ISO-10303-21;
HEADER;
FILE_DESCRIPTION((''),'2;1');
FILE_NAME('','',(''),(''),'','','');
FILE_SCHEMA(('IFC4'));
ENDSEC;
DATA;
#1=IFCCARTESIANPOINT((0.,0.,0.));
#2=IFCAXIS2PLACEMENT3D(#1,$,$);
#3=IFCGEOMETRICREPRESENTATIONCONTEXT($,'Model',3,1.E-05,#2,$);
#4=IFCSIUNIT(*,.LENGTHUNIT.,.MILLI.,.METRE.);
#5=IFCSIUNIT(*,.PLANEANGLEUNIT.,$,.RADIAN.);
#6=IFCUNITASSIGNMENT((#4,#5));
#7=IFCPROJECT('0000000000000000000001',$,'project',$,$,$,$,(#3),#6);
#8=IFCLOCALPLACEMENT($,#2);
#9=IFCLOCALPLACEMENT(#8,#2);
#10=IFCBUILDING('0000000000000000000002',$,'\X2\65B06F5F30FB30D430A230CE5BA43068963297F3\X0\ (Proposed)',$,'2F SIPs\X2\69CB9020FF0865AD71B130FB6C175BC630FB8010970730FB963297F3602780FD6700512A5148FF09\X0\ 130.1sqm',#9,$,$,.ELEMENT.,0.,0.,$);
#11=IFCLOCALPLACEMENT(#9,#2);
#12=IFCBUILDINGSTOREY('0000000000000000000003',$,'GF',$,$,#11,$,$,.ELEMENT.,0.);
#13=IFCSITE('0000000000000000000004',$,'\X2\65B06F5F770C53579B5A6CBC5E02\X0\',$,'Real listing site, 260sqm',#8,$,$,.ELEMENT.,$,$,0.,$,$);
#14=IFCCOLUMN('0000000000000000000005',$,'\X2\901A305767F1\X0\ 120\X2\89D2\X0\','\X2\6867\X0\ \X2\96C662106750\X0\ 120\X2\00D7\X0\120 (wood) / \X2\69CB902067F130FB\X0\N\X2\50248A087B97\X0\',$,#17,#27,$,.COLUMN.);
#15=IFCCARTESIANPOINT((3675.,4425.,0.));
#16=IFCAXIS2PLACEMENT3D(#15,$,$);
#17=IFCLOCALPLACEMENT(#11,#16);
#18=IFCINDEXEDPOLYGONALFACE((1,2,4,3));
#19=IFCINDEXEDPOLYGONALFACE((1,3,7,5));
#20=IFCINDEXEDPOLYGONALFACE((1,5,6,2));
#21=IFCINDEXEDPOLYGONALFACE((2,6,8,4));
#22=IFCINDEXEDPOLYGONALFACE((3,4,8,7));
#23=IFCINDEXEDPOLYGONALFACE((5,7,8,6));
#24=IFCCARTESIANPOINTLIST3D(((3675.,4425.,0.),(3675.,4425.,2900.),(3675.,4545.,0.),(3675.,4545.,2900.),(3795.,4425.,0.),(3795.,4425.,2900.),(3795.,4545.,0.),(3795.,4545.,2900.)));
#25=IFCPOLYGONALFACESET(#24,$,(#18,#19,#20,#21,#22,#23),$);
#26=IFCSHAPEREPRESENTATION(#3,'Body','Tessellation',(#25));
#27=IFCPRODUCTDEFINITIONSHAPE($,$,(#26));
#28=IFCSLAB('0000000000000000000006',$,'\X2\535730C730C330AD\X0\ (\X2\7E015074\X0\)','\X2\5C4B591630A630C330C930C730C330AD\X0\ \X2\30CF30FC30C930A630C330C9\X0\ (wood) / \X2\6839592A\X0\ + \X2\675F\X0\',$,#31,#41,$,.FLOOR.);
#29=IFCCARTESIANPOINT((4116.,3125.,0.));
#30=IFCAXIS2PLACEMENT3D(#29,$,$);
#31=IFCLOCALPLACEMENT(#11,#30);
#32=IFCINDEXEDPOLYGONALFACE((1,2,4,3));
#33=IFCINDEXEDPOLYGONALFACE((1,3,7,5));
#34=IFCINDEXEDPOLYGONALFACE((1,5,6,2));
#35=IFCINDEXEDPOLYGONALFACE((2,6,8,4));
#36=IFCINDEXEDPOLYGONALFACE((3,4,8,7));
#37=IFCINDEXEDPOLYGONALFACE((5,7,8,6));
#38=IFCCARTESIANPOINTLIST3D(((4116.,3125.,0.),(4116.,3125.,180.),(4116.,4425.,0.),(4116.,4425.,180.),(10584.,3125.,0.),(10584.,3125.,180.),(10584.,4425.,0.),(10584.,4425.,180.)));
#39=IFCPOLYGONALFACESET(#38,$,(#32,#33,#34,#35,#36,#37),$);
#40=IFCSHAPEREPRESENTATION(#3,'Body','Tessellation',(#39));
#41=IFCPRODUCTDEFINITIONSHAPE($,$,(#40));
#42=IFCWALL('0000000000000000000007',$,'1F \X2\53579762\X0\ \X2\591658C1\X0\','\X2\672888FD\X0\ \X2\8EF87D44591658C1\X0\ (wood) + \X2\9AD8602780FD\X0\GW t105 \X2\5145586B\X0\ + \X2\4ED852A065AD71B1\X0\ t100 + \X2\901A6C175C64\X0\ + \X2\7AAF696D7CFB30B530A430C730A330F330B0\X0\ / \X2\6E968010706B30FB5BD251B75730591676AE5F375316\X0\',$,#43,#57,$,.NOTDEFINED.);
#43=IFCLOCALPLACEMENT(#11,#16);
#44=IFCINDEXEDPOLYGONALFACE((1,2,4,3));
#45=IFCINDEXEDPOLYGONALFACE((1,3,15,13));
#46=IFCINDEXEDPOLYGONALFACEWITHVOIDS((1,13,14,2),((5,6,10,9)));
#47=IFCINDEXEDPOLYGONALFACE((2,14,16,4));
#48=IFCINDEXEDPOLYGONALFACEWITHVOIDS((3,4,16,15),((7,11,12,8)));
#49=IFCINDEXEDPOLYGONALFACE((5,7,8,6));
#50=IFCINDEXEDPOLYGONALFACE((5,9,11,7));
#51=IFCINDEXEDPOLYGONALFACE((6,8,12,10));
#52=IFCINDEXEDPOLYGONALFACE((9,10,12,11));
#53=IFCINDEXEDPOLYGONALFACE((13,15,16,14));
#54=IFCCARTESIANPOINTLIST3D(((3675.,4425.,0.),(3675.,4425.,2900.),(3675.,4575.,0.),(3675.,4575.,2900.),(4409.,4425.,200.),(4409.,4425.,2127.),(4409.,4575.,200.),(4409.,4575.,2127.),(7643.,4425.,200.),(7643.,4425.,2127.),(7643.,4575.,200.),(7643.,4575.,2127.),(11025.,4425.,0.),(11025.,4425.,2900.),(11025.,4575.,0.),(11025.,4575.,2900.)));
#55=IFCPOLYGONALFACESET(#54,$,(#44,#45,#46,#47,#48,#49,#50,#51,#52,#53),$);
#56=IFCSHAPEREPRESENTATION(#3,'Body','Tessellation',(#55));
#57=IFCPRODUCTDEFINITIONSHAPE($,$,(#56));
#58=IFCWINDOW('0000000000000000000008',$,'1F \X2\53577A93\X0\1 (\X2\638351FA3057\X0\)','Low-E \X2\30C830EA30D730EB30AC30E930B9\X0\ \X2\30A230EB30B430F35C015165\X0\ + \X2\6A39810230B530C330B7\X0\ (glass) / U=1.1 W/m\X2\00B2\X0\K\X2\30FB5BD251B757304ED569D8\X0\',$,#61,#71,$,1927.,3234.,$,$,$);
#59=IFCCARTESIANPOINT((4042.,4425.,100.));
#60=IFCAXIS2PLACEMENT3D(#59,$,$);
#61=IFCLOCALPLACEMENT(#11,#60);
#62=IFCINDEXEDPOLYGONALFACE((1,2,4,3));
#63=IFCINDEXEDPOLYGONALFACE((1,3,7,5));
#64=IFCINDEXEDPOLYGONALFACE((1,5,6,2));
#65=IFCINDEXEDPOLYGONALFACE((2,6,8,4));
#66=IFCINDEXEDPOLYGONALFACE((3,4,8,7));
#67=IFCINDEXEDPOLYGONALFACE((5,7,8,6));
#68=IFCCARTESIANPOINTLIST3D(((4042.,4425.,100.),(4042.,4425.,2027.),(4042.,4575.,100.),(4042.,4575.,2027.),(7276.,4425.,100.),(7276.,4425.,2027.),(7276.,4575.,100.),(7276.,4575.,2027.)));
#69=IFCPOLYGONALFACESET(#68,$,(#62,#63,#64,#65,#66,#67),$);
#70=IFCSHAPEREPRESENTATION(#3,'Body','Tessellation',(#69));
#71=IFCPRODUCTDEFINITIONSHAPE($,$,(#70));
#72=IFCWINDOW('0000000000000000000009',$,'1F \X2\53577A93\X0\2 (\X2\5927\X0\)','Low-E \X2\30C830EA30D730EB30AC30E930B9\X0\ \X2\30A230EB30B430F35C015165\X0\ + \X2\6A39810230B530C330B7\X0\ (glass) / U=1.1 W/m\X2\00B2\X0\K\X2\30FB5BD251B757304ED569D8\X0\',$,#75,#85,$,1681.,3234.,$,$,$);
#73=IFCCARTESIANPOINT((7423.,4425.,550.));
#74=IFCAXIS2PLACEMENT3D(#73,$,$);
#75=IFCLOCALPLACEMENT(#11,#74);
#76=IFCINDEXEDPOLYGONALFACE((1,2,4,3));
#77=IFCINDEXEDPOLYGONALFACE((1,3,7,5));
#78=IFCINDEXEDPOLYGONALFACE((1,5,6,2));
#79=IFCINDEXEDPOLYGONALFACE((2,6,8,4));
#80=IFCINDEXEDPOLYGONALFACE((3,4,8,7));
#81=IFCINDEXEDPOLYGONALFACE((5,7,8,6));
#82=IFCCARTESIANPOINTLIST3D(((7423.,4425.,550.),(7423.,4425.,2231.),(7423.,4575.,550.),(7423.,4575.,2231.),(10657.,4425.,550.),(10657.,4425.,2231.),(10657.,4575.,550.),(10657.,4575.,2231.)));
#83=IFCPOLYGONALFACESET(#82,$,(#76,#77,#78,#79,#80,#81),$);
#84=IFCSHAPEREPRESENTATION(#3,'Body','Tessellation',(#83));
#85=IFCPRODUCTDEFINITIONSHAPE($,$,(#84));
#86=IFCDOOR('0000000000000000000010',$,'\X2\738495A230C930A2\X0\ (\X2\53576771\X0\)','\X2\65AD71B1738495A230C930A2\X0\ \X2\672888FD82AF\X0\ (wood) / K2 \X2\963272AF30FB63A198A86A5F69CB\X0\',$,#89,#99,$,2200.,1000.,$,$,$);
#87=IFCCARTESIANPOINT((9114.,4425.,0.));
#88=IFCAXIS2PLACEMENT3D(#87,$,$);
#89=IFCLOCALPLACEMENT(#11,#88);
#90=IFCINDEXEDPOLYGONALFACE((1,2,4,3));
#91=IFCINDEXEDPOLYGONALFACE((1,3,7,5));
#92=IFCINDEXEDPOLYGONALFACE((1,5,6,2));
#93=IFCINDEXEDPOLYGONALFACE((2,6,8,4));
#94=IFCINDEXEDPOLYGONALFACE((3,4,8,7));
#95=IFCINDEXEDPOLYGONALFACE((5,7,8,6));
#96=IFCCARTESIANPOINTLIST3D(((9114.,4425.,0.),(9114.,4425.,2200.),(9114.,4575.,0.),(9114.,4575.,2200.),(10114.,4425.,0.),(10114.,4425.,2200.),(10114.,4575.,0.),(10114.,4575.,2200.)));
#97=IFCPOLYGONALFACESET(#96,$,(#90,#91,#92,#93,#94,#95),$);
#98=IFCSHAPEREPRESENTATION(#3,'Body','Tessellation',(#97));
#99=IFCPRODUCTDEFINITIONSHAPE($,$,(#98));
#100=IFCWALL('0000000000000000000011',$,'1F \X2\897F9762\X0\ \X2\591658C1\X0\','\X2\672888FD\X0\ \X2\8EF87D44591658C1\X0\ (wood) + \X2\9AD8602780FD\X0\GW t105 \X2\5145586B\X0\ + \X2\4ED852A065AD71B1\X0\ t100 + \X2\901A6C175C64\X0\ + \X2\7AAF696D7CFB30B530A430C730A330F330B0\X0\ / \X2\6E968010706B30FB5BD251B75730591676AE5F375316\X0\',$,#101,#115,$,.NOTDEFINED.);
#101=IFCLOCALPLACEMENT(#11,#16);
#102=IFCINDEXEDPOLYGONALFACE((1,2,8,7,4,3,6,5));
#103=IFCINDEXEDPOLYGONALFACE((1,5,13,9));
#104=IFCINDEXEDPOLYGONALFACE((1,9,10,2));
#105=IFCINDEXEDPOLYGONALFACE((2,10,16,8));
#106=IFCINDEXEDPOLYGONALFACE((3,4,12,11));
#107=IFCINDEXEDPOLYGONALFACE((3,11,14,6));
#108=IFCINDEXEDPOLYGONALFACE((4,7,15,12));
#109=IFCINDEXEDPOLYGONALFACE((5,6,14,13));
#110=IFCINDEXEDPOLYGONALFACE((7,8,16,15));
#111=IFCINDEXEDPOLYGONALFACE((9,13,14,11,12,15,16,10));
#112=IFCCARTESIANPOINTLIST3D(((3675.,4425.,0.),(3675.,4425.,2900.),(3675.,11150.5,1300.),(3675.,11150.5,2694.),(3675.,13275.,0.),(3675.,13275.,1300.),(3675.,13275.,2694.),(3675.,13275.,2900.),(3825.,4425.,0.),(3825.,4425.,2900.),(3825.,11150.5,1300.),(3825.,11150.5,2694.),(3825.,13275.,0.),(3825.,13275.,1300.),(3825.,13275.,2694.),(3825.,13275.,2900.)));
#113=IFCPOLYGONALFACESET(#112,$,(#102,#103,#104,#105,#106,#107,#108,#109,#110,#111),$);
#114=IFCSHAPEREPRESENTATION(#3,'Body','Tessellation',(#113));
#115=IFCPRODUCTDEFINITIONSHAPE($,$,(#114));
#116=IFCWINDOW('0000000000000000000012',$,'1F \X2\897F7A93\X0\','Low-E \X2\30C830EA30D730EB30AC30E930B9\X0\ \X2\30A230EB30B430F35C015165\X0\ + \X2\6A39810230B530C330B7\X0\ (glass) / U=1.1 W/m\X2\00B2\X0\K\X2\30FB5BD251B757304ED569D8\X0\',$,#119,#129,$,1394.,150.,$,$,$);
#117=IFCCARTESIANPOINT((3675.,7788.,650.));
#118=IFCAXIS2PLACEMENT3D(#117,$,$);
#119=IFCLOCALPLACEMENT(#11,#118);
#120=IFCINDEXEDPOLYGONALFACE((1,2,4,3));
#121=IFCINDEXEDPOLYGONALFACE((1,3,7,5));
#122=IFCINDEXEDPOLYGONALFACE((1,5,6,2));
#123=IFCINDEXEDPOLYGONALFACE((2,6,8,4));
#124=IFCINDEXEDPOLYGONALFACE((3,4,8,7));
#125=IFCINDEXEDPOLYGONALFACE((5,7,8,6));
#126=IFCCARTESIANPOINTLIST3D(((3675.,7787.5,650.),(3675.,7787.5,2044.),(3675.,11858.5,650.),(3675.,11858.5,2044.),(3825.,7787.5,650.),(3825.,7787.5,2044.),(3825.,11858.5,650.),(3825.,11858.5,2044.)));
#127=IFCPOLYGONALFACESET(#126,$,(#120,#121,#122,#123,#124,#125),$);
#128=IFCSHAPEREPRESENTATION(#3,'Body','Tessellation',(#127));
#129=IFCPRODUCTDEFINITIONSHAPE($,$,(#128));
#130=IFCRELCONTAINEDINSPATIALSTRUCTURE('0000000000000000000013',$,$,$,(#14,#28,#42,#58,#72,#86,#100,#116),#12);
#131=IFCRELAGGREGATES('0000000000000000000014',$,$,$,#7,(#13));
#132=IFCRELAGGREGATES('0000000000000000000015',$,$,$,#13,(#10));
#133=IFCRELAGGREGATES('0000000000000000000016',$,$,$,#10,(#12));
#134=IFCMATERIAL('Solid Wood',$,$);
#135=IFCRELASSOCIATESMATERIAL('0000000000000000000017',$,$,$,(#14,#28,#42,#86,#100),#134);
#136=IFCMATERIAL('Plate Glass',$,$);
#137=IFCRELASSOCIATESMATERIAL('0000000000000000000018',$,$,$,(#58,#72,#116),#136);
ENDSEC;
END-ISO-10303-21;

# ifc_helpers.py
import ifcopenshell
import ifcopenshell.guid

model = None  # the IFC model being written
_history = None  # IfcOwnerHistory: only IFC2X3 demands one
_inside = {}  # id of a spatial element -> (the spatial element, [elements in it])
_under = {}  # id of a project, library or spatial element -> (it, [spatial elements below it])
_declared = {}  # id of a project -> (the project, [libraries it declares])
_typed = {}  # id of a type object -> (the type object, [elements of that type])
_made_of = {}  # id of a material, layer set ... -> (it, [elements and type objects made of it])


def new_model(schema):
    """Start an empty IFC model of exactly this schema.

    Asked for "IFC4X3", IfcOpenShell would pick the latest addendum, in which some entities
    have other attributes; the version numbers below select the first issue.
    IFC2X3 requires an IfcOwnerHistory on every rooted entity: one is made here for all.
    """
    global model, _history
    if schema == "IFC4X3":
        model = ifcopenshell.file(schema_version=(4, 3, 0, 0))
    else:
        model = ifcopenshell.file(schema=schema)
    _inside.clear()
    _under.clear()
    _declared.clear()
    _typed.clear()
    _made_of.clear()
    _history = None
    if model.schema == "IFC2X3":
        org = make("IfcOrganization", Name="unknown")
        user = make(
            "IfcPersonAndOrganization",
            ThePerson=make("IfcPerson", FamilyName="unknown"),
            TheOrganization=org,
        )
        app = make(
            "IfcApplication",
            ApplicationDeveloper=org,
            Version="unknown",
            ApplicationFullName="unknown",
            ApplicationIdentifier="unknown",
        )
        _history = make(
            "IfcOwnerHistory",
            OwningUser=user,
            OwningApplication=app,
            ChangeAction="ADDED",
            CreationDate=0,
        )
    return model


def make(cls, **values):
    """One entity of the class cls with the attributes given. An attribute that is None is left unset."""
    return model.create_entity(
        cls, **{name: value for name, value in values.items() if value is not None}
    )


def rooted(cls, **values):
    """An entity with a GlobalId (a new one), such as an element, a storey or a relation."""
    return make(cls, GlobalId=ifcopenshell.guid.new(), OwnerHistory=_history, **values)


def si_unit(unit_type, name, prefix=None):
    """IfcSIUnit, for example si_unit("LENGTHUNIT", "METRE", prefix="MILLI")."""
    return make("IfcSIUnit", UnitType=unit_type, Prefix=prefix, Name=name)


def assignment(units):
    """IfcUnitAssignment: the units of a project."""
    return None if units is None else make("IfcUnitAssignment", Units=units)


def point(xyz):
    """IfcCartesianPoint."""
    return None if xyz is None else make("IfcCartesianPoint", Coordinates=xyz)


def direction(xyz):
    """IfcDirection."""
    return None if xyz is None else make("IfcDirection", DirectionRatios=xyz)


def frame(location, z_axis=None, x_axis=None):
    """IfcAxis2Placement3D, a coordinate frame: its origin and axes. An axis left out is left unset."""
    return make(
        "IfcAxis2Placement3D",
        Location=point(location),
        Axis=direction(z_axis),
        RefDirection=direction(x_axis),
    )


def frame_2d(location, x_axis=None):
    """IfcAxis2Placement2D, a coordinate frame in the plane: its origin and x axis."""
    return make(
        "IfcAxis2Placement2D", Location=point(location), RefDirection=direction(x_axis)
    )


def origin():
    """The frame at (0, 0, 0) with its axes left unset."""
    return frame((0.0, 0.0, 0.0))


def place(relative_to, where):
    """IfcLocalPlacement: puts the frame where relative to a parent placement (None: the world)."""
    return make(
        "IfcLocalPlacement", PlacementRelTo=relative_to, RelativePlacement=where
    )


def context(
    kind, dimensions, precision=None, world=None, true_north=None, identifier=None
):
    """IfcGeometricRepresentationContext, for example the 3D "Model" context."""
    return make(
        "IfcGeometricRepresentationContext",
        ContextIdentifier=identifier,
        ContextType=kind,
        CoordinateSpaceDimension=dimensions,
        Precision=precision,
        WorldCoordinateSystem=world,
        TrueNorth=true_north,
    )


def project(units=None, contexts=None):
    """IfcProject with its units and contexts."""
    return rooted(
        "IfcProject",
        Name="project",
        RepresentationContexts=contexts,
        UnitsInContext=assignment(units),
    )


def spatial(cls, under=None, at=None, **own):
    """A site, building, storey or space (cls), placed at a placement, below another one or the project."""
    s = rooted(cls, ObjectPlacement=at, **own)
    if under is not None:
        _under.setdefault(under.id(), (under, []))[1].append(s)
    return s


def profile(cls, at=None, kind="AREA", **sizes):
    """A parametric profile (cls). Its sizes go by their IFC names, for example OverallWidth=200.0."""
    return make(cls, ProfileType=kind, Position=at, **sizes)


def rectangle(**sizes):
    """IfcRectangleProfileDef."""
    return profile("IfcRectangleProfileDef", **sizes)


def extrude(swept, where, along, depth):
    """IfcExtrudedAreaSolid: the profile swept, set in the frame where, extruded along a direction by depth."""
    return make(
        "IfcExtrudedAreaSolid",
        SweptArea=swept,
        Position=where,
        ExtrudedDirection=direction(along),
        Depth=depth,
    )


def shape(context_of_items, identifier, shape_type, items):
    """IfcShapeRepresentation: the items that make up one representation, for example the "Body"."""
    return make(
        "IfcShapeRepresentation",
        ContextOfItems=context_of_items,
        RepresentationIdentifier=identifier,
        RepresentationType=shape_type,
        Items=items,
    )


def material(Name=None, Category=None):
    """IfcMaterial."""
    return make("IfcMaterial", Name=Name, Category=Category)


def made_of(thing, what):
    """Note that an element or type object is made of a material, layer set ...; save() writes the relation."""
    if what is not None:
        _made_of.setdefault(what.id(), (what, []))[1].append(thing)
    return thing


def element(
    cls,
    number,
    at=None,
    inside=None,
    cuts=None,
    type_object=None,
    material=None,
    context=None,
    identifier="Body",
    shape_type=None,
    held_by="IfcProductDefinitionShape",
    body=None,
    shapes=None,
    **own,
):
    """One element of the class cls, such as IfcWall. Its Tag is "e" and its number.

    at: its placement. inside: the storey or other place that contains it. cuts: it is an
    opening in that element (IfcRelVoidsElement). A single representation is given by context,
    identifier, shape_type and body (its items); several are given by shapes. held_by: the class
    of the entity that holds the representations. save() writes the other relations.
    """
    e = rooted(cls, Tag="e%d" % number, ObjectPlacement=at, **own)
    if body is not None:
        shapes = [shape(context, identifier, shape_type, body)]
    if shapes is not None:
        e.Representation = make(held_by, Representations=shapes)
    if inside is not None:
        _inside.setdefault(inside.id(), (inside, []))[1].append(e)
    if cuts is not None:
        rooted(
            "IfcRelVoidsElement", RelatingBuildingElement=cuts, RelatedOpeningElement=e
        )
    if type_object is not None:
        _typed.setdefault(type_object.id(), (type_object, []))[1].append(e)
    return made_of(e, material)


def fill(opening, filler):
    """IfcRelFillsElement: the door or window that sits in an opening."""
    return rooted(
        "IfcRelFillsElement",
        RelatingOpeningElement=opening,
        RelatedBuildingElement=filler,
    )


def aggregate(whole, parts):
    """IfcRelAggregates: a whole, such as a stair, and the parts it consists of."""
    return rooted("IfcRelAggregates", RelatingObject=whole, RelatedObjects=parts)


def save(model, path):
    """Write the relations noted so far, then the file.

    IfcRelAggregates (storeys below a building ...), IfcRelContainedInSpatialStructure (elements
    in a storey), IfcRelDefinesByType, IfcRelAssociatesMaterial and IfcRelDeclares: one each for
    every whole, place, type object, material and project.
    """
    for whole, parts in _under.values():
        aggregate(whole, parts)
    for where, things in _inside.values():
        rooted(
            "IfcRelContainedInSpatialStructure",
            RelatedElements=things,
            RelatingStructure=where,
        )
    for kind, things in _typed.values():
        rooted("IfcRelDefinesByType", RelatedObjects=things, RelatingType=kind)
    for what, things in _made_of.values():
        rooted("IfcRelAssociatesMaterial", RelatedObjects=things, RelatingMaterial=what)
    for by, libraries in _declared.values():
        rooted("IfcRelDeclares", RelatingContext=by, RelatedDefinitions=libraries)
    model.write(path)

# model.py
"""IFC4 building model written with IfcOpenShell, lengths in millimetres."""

from ifc_helpers import new_model, si_unit, frame, frame_2d, origin, place, context, project, spatial, rectangle, extrude, material, element, fill, save


model = new_model("IFC4")

# Units and contexts
model_context = context("Model", 3, precision=1e-05, world=origin())
ifc_project = project(units=[si_unit("LENGTHUNIT", "METRE", prefix="MILLI"), si_unit("PLANEANGLEUNIT", "RADIAN")], contexts=[model_context])

# Site, building, storey
site_placement = place(None, origin())
site = spatial("IfcSite", under=ifc_project, at=site_placement, Name="新潟県南魚沼市", ObjectType="Real listing site, 260sqm", CompositionType="ELEMENT", RefElevation=0.0)
building_placement = place(site_placement, origin())
building = spatial("IfcBuilding", under=site, at=building_placement, Name="新潟・ピアノ室と防音 (Proposed)", ObjectType="2F SIPs構造（断熱・気密・耐震・防音性能最優先） 130.1sqm", CompositionType="ELEMENT", ElevationOfRefHeight=0.0, ElevationOfTerrain=0.0)
storey_placement = place(building_placement, origin())
storey = spatial("IfcBuildingStorey", under=building, at=storey_placement, Name="GF", CompositionType="ELEMENT", Elevation=0.0)

# Column
ifc_material_1 = material(Name="Solid Wood")
column_placement = place(storey_placement, frame((3675.0, 4425.0, 0.0)))
element("IfcColumn", 1, at=column_placement, inside=storey, material=ifc_material_1, Name="通し柱 120角", Description="桧 集成材 120×120 (wood) / 構造柱・N値計算", PredefinedType="COLUMN", context=model_context, shape_type="SweptSolid", body=[
    extrude(rectangle(XDim=120.0, YDim=120.0, at=frame_2d((60.0, 60.0))), frame((3675.0, 4425.0, 0.0)), (0.0, 0.0, 1.0), 2900.0),
])

# Slab
slab_1_placement = place(storey_placement, frame((4116.0, 3125.0, 0.0)))
element("IfcSlab", 2, at=slab_1_placement, inside=storey, material=ifc_material_1, Name="南デッキ (縁側)", Description="屋外ウッドデッキ ハードウッド (wood) / 根太 + 束", PredefinedType="FLOOR", context=model_context, shape_type="SweptSolid", body=[
    extrude(rectangle(XDim=6468.0, YDim=1300.0, at=frame_2d((3234.0, 650.0))), frame((4116.0, 3125.0, 0.0)), (0.0, 0.0, 1.0), 180.0),
])

# Wall, openings, windows, door
wall_1_placement = place(storey_placement, frame((3675.0, 4425.0, 0.0)))
wall_1 = element("IfcWall", 3, at=wall_1_placement, inside=storey, material=ifc_material_1, Name="1F 南面 外壁", Description="木製 軸組外壁 (wood) + 高性能GW t105 充填 + 付加断熱 t100 + 通気層 + 窯業系サイディング / 準耐火・寒冷地外皮強化", PredefinedType="NOTDEFINED", context=model_context, shape_type="SweptSolid", body=[
    extrude(rectangle(XDim=7350.0, YDim=150.0, at=frame_2d((3675.0, 75.0))), frame((3675.0, 4425.0, 0.0)), (0.0, 0.0, 1.0), 2900.0),
])
opening_1_placement = place(storey_placement, frame((4042.0, 4425.0, 100.0)))
opening_1 = element("IfcOpeningElement", 4, at=opening_1_placement, cuts=wall_1, PredefinedType="NOTDEFINED", context=model_context, shape_type="SweptSolid", body=[
    extrude(rectangle(XDim=3234.0, YDim=150.0, at=frame_2d((1617.0, 75.0))), frame((4042.0, 4425.0, 100.0)), (0.0, 0.0, 1.0), 1927.0),
])
opening_2_placement = place(storey_placement, frame((7423.0, 4425.0, 550.0)))
opening_2 = element("IfcOpeningElement", 5, at=opening_2_placement, cuts=wall_1, PredefinedType="NOTDEFINED", context=model_context, shape_type="SweptSolid", body=[
    extrude(rectangle(XDim=3234.0, YDim=150.0, at=frame_2d((1617.0, 75.0))), frame((7423.0, 4425.0, 550.0)), (0.0, 0.0, 1.0), 1681.0),
])
opening_3_placement = place(storey_placement, frame((9114.0, 4425.0, 0.0)))
opening_3 = element("IfcOpeningElement", 6, at=opening_3_placement, cuts=wall_1, PredefinedType="NOTDEFINED", context=model_context, shape_type="SweptSolid", body=[
    extrude(rectangle(XDim=1000.0, YDim=150.0, at=frame_2d((500.0, 75.0))), frame((9114.0, 4425.0, 0.0)), (0.0, 0.0, 1.0), 2200.0),
])
ifc_material_2 = material(Name="Plate Glass")
window_1_placement = place(storey_placement, frame((4042.0, 4425.0, 100.0)))
window_1 = element("IfcWindow", 7, at=window_1_placement, inside=storey, material=ifc_material_2, Name="1F 南窓1 (掃出し)", Description="Low-E トリプルガラス アルゴン封入 + 樹脂サッシ (glass) / U=1.1 W/m²K・寒冷地仕様", OverallHeight=1927.0, OverallWidth=3234.0, context=model_context, shape_type="SweptSolid", body=[
    extrude(rectangle(XDim=3234.0, YDim=150.0, at=frame_2d((1617.0, 75.0))), frame((4042.0, 4425.0, 100.0)), (0.0, 0.0, 1.0), 1927.0),
])
fill(opening_1, window_1)
window_2_placement = place(storey_placement, frame((7423.0, 4425.0, 550.0)))
window_2 = element("IfcWindow", 8, at=window_2_placement, inside=storey, material=ifc_material_2, Name="1F 南窓2 (大)", Description="Low-E トリプルガラス アルゴン封入 + 樹脂サッシ (glass) / U=1.1 W/m²K・寒冷地仕様", OverallHeight=1681.0, OverallWidth=3234.0, context=model_context, shape_type="SweptSolid", body=[
    extrude(rectangle(XDim=3234.0, YDim=150.0, at=frame_2d((1617.0, 75.0))), frame((7423.0, 4425.0, 550.0)), (0.0, 0.0, 1.0), 1681.0),
])
fill(opening_2, window_2)
door_placement = place(storey_placement, frame((9114.0, 4425.0, 0.0)))
door = element("IfcDoor", 9, at=door_placement, inside=storey, material=ifc_material_1, Name="玄関ドア (南東)", Description="断熱玄関ドア 木製芯 (wood) / K2 防犯・採風機構", OverallHeight=2200.0, OverallWidth=1000.0, context=model_context, shape_type="SweptSolid", body=[
    extrude(rectangle(XDim=1000.0, YDim=150.0, at=frame_2d((500.0, 75.0))), frame((9114.0, 4425.0, 0.0)), (0.0, 0.0, 1.0), 2200.0),
])
fill(opening_3, door)

# Wall, opening, window
wall_2_placement = place(storey_placement, frame((3675.0, 4425.0, 0.0)))
wall_2 = element("IfcWall", 10, at=wall_2_placement, inside=storey, material=ifc_material_1, Name="1F 西面 外壁", Description="木製 軸組外壁 (wood) + 高性能GW t105 充填 + 付加断熱 t100 + 通気層 + 窯業系サイディング / 準耐火・寒冷地外皮強化", PredefinedType="NOTDEFINED", context=model_context, shape_type="SweptSolid", body=[
    extrude(rectangle(XDim=150.0, YDim=8850.0, at=frame_2d((75.0, 4425.0))), frame((3675.0, 4425.0, 0.0)), (0.0, 0.0, 1.0), 2900.0),
])
opening_4_placement = place(storey_placement, frame((3675.0, 7788.0, 650.0)))
opening_4 = element("IfcOpeningElement", 11, at=opening_4_placement, cuts=wall_2, PredefinedType="NOTDEFINED", context=model_context, shape_type="SweptSolid", body=[
    extrude(rectangle(XDim=150.0, YDim=4071.0, at=frame_2d((75.0, 2035.0))), frame((3675.0, 7788.0, 650.0)), (0.0, 0.0, 1.0), 1394.0),
])
window_3_placement = place(storey_placement, frame((3675.0, 7788.0, 650.0)))
window_3 = element("IfcWindow", 12, at=window_3_placement, inside=storey, material=ifc_material_2, Name="1F 西窓", Description="Low-E トリプルガラス アルゴン封入 + 樹脂サッシ (glass) / U=1.1 W/m²K・寒冷地仕様", OverallHeight=1394.0, OverallWidth=150.0, context=model_context, shape_type="SweptSolid", body=[
    extrude(rectangle(XDim=150.0, YDim=4071.0, at=frame_2d((75.0, 2035.0))), frame((3675.0, 7788.0, 650.0)), (0.0, 0.0, 1.0), 1394.0),
])
fill(opening_4, window_3)

save(model, "model.ifc")
